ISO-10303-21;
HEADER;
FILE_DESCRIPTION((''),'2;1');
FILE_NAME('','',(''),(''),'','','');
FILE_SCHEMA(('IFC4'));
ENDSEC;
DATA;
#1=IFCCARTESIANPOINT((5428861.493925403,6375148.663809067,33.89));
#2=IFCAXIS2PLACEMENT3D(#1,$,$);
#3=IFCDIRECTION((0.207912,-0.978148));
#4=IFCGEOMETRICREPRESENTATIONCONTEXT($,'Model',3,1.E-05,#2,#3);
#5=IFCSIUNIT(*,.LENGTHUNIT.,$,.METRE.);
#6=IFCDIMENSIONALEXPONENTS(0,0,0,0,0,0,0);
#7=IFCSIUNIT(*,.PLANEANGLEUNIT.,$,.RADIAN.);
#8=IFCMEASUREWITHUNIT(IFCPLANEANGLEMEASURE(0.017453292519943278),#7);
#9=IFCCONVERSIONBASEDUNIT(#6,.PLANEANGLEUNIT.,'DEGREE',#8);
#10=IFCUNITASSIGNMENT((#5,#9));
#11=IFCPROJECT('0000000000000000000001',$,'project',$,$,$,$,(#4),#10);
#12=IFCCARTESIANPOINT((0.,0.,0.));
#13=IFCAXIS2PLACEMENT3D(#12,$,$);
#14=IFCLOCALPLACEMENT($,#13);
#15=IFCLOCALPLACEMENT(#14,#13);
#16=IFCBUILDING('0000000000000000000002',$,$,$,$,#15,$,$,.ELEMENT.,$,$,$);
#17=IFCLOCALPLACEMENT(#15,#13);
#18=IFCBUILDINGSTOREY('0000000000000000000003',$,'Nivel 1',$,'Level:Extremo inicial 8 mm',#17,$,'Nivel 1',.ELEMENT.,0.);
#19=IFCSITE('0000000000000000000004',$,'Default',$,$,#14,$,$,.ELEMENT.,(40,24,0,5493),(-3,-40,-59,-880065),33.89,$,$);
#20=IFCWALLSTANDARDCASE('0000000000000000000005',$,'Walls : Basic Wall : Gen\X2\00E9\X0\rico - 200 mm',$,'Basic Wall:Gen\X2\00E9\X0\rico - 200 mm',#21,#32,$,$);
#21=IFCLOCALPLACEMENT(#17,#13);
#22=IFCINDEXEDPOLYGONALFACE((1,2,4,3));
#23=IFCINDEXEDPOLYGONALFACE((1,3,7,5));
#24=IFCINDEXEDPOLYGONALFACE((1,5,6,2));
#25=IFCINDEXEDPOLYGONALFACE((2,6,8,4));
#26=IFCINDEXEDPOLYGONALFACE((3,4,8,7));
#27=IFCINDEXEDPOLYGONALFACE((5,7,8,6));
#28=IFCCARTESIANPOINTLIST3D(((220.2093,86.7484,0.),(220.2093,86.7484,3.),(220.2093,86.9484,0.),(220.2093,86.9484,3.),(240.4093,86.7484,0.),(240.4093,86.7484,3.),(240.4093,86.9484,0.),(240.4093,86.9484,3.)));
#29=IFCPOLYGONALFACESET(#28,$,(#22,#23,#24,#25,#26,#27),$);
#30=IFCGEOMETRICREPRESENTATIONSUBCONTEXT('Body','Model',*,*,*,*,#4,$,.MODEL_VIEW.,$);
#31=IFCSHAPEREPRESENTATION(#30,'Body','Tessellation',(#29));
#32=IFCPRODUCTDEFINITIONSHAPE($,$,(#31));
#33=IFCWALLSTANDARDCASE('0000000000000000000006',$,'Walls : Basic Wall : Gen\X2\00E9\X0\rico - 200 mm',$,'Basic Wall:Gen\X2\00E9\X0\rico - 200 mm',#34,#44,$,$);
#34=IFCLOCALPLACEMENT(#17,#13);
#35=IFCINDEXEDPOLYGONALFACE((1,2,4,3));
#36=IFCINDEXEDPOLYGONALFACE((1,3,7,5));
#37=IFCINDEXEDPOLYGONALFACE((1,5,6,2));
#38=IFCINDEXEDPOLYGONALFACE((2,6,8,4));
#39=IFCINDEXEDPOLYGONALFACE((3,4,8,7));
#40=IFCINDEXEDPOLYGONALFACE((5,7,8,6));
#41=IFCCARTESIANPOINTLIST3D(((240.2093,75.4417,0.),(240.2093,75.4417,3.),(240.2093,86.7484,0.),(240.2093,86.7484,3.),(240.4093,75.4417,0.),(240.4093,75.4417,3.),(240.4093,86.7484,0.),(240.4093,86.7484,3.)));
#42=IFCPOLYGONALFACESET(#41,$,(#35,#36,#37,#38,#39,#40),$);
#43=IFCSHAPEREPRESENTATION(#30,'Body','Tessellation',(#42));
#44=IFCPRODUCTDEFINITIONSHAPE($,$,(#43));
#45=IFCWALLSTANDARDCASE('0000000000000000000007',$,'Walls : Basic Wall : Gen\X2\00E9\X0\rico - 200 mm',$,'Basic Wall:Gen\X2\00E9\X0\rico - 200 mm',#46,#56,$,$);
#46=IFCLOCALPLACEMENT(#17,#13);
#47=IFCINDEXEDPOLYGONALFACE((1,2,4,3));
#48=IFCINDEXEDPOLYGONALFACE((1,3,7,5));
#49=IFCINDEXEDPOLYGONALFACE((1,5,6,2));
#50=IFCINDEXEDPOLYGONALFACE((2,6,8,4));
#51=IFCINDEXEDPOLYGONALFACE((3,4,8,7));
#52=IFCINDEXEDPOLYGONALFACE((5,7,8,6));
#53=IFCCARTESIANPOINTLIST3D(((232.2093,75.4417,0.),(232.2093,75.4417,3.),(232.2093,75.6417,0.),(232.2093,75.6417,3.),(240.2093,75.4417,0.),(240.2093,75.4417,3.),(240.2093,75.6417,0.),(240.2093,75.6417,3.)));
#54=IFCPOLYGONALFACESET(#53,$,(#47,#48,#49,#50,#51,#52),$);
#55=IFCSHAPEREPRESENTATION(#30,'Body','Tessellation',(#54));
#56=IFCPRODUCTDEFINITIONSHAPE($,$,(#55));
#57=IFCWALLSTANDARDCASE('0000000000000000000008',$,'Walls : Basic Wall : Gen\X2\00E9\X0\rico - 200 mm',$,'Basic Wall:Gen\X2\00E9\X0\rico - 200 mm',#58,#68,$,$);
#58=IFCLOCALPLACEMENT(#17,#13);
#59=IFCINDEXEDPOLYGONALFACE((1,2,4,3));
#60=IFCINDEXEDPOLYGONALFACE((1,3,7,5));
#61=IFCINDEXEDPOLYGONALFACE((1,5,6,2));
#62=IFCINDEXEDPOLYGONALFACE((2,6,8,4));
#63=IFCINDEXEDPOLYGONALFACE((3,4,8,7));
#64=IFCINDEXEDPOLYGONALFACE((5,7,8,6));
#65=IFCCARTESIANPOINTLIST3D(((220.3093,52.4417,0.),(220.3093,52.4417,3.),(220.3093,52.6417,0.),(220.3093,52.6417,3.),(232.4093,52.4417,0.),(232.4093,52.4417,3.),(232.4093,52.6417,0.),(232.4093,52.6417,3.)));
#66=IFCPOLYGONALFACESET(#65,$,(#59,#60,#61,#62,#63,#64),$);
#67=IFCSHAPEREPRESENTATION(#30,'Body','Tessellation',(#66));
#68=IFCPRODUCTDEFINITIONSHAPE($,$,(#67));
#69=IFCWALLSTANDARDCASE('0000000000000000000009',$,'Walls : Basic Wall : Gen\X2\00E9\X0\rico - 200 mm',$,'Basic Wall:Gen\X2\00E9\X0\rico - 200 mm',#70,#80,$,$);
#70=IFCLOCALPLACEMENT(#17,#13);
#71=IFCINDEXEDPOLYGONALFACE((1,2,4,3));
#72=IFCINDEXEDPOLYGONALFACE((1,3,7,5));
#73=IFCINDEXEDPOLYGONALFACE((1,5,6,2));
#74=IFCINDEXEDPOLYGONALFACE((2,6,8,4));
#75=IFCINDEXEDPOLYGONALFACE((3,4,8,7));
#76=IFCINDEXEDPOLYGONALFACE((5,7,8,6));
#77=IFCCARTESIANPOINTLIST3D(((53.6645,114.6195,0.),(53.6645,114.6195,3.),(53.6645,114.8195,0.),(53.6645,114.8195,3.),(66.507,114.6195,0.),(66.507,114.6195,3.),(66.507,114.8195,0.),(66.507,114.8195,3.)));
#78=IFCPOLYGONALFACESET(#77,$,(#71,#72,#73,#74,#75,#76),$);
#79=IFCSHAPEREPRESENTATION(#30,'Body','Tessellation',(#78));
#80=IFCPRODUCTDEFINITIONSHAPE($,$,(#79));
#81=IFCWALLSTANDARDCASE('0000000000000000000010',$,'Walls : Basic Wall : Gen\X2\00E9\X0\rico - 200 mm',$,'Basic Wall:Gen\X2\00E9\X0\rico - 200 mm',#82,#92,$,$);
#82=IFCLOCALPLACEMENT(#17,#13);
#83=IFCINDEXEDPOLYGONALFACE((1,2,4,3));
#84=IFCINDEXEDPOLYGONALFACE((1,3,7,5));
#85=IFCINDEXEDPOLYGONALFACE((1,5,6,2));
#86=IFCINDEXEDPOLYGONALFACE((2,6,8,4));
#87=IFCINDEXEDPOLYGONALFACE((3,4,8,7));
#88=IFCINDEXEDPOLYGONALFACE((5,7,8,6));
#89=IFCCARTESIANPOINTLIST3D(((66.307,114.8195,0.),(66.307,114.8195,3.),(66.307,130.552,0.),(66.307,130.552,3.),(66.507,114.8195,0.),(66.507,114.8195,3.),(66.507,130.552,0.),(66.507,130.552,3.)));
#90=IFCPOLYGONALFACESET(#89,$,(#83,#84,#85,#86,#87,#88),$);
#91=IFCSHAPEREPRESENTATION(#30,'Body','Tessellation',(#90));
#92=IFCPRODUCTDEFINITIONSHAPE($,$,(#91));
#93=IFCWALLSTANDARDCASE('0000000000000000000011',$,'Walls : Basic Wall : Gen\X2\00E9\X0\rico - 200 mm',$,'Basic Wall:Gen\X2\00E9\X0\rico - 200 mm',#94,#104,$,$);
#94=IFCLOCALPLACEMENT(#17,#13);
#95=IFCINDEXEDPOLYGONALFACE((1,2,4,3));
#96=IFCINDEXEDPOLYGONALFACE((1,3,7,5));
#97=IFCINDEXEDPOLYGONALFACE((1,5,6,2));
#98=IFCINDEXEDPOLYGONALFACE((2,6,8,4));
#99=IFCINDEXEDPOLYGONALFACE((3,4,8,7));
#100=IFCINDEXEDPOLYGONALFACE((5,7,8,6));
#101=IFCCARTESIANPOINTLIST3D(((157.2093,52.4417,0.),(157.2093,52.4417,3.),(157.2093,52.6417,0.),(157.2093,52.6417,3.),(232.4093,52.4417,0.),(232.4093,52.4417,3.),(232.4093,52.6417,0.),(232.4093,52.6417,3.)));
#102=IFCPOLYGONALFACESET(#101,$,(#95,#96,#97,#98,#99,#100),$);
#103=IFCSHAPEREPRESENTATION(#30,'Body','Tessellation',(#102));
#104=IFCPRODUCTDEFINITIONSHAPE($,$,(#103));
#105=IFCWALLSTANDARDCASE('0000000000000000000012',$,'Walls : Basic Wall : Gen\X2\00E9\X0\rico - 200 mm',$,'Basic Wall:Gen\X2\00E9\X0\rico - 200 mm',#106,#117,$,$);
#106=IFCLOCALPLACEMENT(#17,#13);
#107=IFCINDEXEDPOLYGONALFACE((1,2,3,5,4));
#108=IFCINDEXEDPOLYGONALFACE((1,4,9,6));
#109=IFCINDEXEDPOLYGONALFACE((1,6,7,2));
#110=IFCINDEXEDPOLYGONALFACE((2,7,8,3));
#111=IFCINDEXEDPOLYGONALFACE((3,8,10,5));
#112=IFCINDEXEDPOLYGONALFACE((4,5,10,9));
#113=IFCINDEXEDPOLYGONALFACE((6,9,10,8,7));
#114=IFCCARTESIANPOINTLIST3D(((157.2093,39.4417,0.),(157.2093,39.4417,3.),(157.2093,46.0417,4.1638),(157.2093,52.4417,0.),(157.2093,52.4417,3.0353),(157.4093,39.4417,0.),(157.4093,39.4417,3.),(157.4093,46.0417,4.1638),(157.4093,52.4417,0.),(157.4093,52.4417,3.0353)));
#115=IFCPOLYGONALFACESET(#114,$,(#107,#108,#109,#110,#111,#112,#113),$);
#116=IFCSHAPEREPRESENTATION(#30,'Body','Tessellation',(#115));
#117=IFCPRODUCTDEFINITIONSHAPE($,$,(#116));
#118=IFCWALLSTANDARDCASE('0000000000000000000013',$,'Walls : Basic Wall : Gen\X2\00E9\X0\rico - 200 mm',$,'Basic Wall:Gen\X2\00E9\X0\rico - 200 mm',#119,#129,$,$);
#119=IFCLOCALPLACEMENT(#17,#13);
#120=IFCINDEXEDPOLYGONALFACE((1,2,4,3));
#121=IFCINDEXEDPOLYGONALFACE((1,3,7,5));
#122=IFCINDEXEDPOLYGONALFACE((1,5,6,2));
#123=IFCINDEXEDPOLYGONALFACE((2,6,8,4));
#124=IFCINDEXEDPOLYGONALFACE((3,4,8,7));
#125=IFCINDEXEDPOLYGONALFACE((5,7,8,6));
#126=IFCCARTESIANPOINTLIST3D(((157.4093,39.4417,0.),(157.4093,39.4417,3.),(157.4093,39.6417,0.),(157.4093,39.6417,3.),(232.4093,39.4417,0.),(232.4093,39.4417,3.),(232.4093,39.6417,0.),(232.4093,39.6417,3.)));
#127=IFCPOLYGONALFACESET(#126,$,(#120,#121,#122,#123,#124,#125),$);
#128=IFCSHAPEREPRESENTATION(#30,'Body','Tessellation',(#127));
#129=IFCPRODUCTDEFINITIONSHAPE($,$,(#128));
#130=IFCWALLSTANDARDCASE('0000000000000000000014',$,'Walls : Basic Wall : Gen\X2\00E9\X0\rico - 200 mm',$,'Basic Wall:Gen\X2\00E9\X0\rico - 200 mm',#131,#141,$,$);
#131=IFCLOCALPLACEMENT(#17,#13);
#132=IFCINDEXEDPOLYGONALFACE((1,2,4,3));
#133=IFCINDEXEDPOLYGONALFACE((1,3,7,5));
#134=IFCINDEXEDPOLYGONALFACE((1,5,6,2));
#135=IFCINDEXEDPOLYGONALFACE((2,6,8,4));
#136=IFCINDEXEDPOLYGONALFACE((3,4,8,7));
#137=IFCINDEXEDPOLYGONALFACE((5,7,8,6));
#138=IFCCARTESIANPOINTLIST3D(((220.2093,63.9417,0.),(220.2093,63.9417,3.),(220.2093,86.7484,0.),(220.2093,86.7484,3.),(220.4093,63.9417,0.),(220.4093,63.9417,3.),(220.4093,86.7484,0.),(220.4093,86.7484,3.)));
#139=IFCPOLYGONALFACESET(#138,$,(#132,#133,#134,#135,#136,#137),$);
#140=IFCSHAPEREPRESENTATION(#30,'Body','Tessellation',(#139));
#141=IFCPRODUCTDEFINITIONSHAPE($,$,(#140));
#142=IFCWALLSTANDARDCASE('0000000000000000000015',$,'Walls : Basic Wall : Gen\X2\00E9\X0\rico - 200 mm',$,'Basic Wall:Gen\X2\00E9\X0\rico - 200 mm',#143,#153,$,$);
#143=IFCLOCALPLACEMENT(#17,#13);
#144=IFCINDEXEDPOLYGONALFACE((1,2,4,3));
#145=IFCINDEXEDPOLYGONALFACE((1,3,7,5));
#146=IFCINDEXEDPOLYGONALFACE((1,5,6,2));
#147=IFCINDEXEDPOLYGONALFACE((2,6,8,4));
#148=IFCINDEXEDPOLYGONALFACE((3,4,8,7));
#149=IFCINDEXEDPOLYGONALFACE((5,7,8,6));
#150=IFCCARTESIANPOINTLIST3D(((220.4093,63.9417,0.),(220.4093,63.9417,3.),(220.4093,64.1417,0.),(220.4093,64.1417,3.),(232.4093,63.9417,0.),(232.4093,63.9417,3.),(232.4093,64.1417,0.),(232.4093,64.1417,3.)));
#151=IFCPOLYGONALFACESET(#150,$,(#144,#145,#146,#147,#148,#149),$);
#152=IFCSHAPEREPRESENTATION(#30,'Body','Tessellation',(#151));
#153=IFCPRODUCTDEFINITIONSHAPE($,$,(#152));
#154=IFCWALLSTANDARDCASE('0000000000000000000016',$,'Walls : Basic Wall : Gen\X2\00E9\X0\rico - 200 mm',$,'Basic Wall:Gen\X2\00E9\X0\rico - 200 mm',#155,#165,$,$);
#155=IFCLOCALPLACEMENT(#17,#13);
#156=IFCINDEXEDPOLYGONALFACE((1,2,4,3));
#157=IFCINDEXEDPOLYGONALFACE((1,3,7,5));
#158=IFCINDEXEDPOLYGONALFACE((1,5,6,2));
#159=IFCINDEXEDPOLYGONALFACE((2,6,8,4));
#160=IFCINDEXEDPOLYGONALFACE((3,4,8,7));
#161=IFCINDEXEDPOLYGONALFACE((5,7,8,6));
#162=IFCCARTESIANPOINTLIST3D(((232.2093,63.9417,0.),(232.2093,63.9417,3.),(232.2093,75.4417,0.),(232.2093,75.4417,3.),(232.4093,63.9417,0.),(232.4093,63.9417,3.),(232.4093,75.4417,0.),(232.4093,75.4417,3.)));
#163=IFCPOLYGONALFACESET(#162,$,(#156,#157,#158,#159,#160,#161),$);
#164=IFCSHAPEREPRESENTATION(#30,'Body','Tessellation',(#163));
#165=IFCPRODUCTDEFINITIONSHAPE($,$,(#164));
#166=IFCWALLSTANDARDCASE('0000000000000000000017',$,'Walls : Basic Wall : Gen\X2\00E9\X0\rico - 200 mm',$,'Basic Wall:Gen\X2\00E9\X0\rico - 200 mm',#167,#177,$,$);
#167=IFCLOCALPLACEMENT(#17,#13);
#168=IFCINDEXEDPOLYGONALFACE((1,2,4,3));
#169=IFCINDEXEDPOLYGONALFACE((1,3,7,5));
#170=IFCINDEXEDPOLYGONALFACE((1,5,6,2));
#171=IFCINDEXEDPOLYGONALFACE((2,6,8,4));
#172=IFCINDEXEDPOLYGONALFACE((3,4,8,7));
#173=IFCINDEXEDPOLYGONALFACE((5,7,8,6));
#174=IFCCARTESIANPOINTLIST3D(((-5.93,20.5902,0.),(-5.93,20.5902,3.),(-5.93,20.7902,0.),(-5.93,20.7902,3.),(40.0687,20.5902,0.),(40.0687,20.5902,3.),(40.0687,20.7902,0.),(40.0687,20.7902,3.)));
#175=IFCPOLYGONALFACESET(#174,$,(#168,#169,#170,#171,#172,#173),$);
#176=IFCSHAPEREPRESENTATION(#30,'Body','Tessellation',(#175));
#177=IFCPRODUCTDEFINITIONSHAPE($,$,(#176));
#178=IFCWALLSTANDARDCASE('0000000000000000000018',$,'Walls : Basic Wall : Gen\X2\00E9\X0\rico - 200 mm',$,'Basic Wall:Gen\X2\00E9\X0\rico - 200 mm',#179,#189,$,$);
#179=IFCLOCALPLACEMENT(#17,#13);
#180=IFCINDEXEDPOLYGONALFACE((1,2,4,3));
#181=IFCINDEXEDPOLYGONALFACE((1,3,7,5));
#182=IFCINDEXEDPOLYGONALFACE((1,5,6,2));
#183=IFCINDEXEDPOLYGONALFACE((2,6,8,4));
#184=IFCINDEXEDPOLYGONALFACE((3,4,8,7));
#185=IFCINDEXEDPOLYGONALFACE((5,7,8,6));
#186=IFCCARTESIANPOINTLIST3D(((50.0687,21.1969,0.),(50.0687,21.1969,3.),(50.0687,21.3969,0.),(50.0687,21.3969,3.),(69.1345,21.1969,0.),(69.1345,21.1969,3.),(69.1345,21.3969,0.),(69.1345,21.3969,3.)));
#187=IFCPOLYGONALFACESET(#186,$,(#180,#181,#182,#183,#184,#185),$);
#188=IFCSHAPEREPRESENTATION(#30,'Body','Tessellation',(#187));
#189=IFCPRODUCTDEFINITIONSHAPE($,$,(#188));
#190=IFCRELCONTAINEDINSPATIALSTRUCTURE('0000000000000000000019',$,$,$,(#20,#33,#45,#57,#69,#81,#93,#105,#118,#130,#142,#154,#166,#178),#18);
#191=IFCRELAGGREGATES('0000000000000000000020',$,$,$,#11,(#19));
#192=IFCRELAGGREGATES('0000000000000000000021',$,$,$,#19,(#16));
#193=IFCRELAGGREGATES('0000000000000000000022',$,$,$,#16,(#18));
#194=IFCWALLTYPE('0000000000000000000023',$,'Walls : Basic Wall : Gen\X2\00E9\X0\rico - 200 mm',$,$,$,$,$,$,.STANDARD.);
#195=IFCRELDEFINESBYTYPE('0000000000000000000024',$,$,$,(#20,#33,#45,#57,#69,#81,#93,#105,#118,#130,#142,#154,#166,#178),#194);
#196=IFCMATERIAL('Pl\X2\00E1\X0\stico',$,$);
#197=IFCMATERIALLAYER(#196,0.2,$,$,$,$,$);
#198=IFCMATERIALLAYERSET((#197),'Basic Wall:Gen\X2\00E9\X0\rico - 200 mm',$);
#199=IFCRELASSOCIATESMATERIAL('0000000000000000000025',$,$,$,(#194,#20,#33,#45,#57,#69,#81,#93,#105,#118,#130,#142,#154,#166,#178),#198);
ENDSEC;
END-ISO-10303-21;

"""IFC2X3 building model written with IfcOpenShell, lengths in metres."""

from ifc_helpers import new_model, entity, si_unit, converted_unit, direction, frame, frame_2d, origin, place, context, subcontext, project, spatial, polyline, rectangle, extrude, clip, bounded_halfspace, material, layer, layer_set, layer_usage, type_object, element, save


model = new_model("IFC2X3")

# Units and contexts
model_context = context("Model", 3, precision=1e-05, world=frame((5428861.493925403, 6375148.663809067, 33.89)), true_north=direction((0.207912, -0.978148)))
body_context = subcontext(model_context, "Body", "Model", "MODEL_VIEW")
ifc_project = project(units=[si_unit("LENGTHUNIT", "METRE"), converted_unit("PLANEANGLEUNIT", "DEGREE", entity("IfcPlaneAngleMeasure", 0.017453292519943278), si_unit("PLANEANGLEUNIT", "RADIAN"), dimensions=[0, 0, 0, 0, 0, 0, 0])], contexts=[model_context])

# Site, building, storey
site_placement = place(None, origin())
site = spatial("IfcSite", under=ifc_project, at=site_placement, Name="Default", CompositionType="ELEMENT", RefLatitude=(40, 24, 0, 5493), RefLongitude=(-3, -40, -59, -880065), RefElevation=33.89)
building_placement = place(site_placement, origin())
building = spatial("IfcBuilding", under=site, at=building_placement, CompositionType="ELEMENT")
storey_placement = place(building_placement, origin())
storey = spatial("IfcBuildingStorey", under=building, at=storey_placement, Name="Nivel 1", ObjectType="Level:Extremo inicial 8 mm", LongName="Nivel 1", CompositionType="ELEMENT", Elevation=0.0)

# Walls
ifc_material_1 = material(Name="Plástico")
ifc_layer_1 = layer(ifc_material_1, 0.2)
ifc_layer_set_1 = layer_set([ifc_layer_1], Name="Basic Wall:Genérico - 200 mm")
ifc_layer_usage_1 = layer_usage(ifc_layer_set_1, "AXIS2", "NEGATIVE", 0.1)
wall_type = type_object("IfcWallType", Name="Walls : Basic Wall : Genérico - 200 mm", PredefinedType="STANDARD", material=ifc_layer_set_1)
wall_1_placement = place(storey_placement, frame((220.2093, 86.8484, 0.0)))
element("IfcWallStandardCase", 1, at=wall_1_placement, inside=storey, type_object=wall_type, material=ifc_layer_usage_1, Name="Walls : Basic Wall : Genérico - 200 mm", ObjectType="Basic Wall:Genérico - 200 mm", context=body_context, shape_type="SweptSolid", body=[
    extrude(rectangle(XDim=20.2, YDim=0.2, at=frame_2d((10.1, 0.0), x_axis=(-1.0, 0.0))), origin(), (0.0, 0.0, 1.0), 3.0),
])
ifc_layer_usage_2 = layer_usage(ifc_layer_set_1, "AXIS2", "NEGATIVE", 0.1)
wall_2_placement = place(storey_placement, frame((240.3093, 86.7484, 0.0), z_axis=(0.0, 0.0, 1.0), x_axis=(0.0, -1.0, 0.0)))
element("IfcWallStandardCase", 2, at=wall_2_placement, inside=storey, type_object=wall_type, material=ifc_layer_usage_2, Name="Walls : Basic Wall : Genérico - 200 mm", ObjectType="Basic Wall:Genérico - 200 mm", context=body_context, shape_type="SweptSolid", body=[
    extrude(rectangle(XDim=11.3067, YDim=0.2, at=frame_2d((5.6533, 0.0), x_axis=(-1.0, 0.0))), origin(), (0.0, 0.0, 1.0), 3.0),
])
ifc_layer_usage_3 = layer_usage(ifc_layer_set_1, "AXIS2", "NEGATIVE", 0.1)
wall_3_placement = place(storey_placement, frame((240.2093, 75.5417, 0.0), z_axis=(0.0, 0.0, 1.0), x_axis=(-1.0, 0.0, 0.0)))
element("IfcWallStandardCase", 3, at=wall_3_placement, inside=storey, type_object=wall_type, material=ifc_layer_usage_3, Name="Walls : Basic Wall : Genérico - 200 mm", ObjectType="Basic Wall:Genérico - 200 mm", context=body_context, shape_type="SweptSolid", body=[
    extrude(rectangle(XDim=8.0, YDim=0.2, at=frame_2d((4.0, 0.0), x_axis=(-1.0, 0.0))), origin(), (0.0, 0.0, 1.0), 3.0),
])
ifc_layer_usage_4 = layer_usage(ifc_layer_set_1, "AXIS2", "NEGATIVE", 0.1)
wall_4_placement = place(storey_placement, frame((232.4093, 52.5417, 0.0), z_axis=(0.0, 0.0, 1.0), x_axis=(-1.0, 0.0, 0.0)))
element("IfcWallStandardCase", 4, at=wall_4_placement, inside=storey, type_object=wall_type, material=ifc_layer_usage_4, Name="Walls : Basic Wall : Genérico - 200 mm", ObjectType="Basic Wall:Genérico - 200 mm", context=body_context, shape_type="SweptSolid", body=[
    extrude(rectangle(XDim=12.1, YDim=0.2, at=frame_2d((6.05, 0.0), x_axis=(-1.0, 0.0))), origin(), (0.0, 0.0, 1.0), 3.0),
])
ifc_layer_usage_5 = layer_usage(ifc_layer_set_1, "AXIS2", "NEGATIVE", 0.1)
wall_5_placement = place(storey_placement, frame((53.6645, 114.7195, 0.0)))
element("IfcWallStandardCase", 5, at=wall_5_placement, inside=storey, type_object=wall_type, material=ifc_layer_usage_5, Name="Walls : Basic Wall : Genérico - 200 mm", ObjectType="Basic Wall:Genérico - 200 mm", context=body_context, shape_type="SweptSolid", body=[
    extrude(rectangle(XDim=12.8425, YDim=0.2, at=frame_2d((6.4213, 0.0), x_axis=(-1.0, 0.0))), origin(), (0.0, 0.0, 1.0), 3.0),
])
ifc_layer_usage_6 = layer_usage(ifc_layer_set_1, "AXIS2", "NEGATIVE", 0.1)
wall_6_placement = place(storey_placement, frame((66.407, 114.8195, 0.0), z_axis=(0.0, 0.0, 1.0), x_axis=(0.0, 1.0, 0.0)))
element("IfcWallStandardCase", 6, at=wall_6_placement, inside=storey, type_object=wall_type, material=ifc_layer_usage_6, Name="Walls : Basic Wall : Genérico - 200 mm", ObjectType="Basic Wall:Genérico - 200 mm", context=body_context, shape_type="SweptSolid", body=[
    extrude(rectangle(XDim=15.7325, YDim=0.2, at=frame_2d((7.8663, 0.0), x_axis=(-1.0, 0.0))), origin(), (0.0, 0.0, 1.0), 3.0),
])
ifc_layer_usage_7 = layer_usage(ifc_layer_set_1, "AXIS2", "NEGATIVE", 0.1)
wall_7_placement = place(storey_placement, frame((232.4093, 52.5417, 0.0), z_axis=(0.0, 0.0, 1.0), x_axis=(-1.0, 0.0, 0.0)))
element("IfcWallStandardCase", 7, at=wall_7_placement, inside=storey, type_object=wall_type, material=ifc_layer_usage_7, Name="Walls : Basic Wall : Genérico - 200 mm", ObjectType="Basic Wall:Genérico - 200 mm", context=body_context, shape_type="SweptSolid", body=[
    extrude(rectangle(XDim=75.2, YDim=0.2, at=frame_2d((37.6, 0.0), x_axis=(-1.0, 0.0))), origin(), (0.0, 0.0, 1.0), 3.0),
])
ifc_layer_usage_8 = layer_usage(ifc_layer_set_1, "AXIS2", "NEGATIVE", 0.1)
wall_8_placement = place(storey_placement, frame((157.3093, 52.4417, 0.0), z_axis=(0.0, 0.0, 1.0), x_axis=(0.0, -1.0, 0.0)))
element("IfcWallStandardCase", 8, at=wall_8_placement, inside=storey, type_object=wall_type, material=ifc_layer_usage_8, Name="Walls : Basic Wall : Genérico - 200 mm", ObjectType="Basic Wall:Genérico - 200 mm", context=body_context, shape_type="Clipping", body=[
    clip(clip(extrude(rectangle(XDim=13.0, YDim=0.2, at=frame_2d((6.5, 0.0), x_axis=(-1.0, 0.0))), origin(), (0.0, 0.0, 1.0), 4.1638), bounded_halfspace(frame((0.0, -0.1, 3.0353), z_axis=(-0.173648, 0.0, 0.984808), x_axis=(0.0, -1.0, 0.0)), False, frame((0.0, -0.1, 3.0353)), polyline([(0.0, 0.0), (6.4, 0.0), (6.4, 0.2), (0.0, 0.2), (0.0, 0.0)]))), bounded_halfspace(frame((6.4, -0.1, 4.1638), z_axis=(0.173648, 0.0, 0.984808), x_axis=(0.0, 1.0, 0.0)), False, frame((6.4, -0.1, 4.1638)), polyline([(0.0, 0.0), (6.6, 0.0), (6.6, 0.2), (0.0, 0.2), (0.0, 0.0)]))),
])
ifc_layer_usage_9 = layer_usage(ifc_layer_set_1, "AXIS2", "NEGATIVE", 0.1)
wall_9_placement = place(storey_placement, frame((157.4093, 39.5417, 0.0)))
element("IfcWallStandardCase", 9, at=wall_9_placement, inside=storey, type_object=wall_type, material=ifc_layer_usage_9, Name="Walls : Basic Wall : Genérico - 200 mm", ObjectType="Basic Wall:Genérico - 200 mm", context=body_context, shape_type="SweptSolid", body=[
    extrude(rectangle(XDim=75.0, YDim=0.2, at=frame_2d((37.5, 0.0), x_axis=(-1.0, 0.0))), origin(), (0.0, 0.0, 1.0), 3.0),
])
ifc_layer_usage_10 = layer_usage(ifc_layer_set_1, "AXIS2", "NEGATIVE", 0.1)
wall_10_placement = place(storey_placement, frame((220.3093, 86.7484, 0.0), z_axis=(0.0, 0.0, 1.0), x_axis=(0.0, -1.0, 0.0)))
element("IfcWallStandardCase", 10, at=wall_10_placement, inside=storey, type_object=wall_type, material=ifc_layer_usage_10, Name="Walls : Basic Wall : Genérico - 200 mm", ObjectType="Basic Wall:Genérico - 200 mm", context=body_context, shape_type="SweptSolid", body=[
    extrude(rectangle(XDim=22.8067, YDim=0.2, at=frame_2d((11.4033, 0.0), x_axis=(-1.0, 0.0))), origin(), (0.0, 0.0, 1.0), 3.0),
])
ifc_layer_usage_11 = layer_usage(ifc_layer_set_1, "AXIS2", "NEGATIVE", 0.1)
wall_11_placement = place(storey_placement, frame((232.4093, 64.0417, 0.0), z_axis=(0.0, 0.0, 1.0), x_axis=(-1.0, 0.0, 0.0)))
element("IfcWallStandardCase", 11, at=wall_11_placement, inside=storey, type_object=wall_type, material=ifc_layer_usage_11, Name="Walls : Basic Wall : Genérico - 200 mm", ObjectType="Basic Wall:Genérico - 200 mm", context=body_context, shape_type="SweptSolid", body=[
    extrude(rectangle(XDim=12.0, YDim=0.2, at=frame_2d((6.0, 0.0), x_axis=(-1.0, 0.0))), origin(), (0.0, 0.0, 1.0), 3.0),
])
ifc_layer_usage_12 = layer_usage(ifc_layer_set_1, "AXIS2", "NEGATIVE", 0.1)
wall_12_placement = place(storey_placement, frame((232.3093, 75.4417, 0.0), z_axis=(0.0, 0.0, 1.0), x_axis=(0.0, -1.0, 0.0)))
element("IfcWallStandardCase", 12, at=wall_12_placement, inside=storey, type_object=wall_type, material=ifc_layer_usage_12, Name="Walls : Basic Wall : Genérico - 200 mm", ObjectType="Basic Wall:Genérico - 200 mm", context=body_context, shape_type="SweptSolid", body=[
    extrude(rectangle(XDim=11.5, YDim=0.2, at=frame_2d((5.75, 0.0), x_axis=(-1.0, 0.0))), origin(), (0.0, 0.0, 1.0), 3.0),
])
ifc_layer_usage_13 = layer_usage(ifc_layer_set_1, "AXIS2", "NEGATIVE", 0.1)
wall_13_placement = place(storey_placement, frame((40.0687, 20.6902, 0.0), z_axis=(0.0, 0.0, 1.0), x_axis=(-1.0, 0.0, 0.0)))
element("IfcWallStandardCase", 13, at=wall_13_placement, inside=storey, type_object=wall_type, material=ifc_layer_usage_13, Name="Walls : Basic Wall : Genérico - 200 mm", ObjectType="Basic Wall:Genérico - 200 mm", context=body_context, shape_type="SweptSolid", body=[
    extrude(rectangle(XDim=45.9987, YDim=0.2, at=frame_2d((22.9993, 0.0), x_axis=(-1.0, 0.0))), origin(), (0.0, 0.0, 1.0), 3.0),
])
ifc_layer_usage_14 = layer_usage(ifc_layer_set_1, "AXIS2", "NEGATIVE", 0.1)
wall_14_placement = place(storey_placement, frame((50.0687, 21.2969, 0.0)))
element("IfcWallStandardCase", 14, at=wall_14_placement, inside=storey, type_object=wall_type, material=ifc_layer_usage_14, Name="Walls : Basic Wall : Genérico - 200 mm", ObjectType="Basic Wall:Genérico - 200 mm", context=body_context, shape_type="SweptSolid", body=[
    extrude(rectangle(XDim=19.0659, YDim=0.2, at=frame_2d((9.5329, 0.0), x_axis=(-1.0, 0.0))), origin(), (0.0, 0.0, 1.0), 3.0),
])

save(model, "model.ifc")
